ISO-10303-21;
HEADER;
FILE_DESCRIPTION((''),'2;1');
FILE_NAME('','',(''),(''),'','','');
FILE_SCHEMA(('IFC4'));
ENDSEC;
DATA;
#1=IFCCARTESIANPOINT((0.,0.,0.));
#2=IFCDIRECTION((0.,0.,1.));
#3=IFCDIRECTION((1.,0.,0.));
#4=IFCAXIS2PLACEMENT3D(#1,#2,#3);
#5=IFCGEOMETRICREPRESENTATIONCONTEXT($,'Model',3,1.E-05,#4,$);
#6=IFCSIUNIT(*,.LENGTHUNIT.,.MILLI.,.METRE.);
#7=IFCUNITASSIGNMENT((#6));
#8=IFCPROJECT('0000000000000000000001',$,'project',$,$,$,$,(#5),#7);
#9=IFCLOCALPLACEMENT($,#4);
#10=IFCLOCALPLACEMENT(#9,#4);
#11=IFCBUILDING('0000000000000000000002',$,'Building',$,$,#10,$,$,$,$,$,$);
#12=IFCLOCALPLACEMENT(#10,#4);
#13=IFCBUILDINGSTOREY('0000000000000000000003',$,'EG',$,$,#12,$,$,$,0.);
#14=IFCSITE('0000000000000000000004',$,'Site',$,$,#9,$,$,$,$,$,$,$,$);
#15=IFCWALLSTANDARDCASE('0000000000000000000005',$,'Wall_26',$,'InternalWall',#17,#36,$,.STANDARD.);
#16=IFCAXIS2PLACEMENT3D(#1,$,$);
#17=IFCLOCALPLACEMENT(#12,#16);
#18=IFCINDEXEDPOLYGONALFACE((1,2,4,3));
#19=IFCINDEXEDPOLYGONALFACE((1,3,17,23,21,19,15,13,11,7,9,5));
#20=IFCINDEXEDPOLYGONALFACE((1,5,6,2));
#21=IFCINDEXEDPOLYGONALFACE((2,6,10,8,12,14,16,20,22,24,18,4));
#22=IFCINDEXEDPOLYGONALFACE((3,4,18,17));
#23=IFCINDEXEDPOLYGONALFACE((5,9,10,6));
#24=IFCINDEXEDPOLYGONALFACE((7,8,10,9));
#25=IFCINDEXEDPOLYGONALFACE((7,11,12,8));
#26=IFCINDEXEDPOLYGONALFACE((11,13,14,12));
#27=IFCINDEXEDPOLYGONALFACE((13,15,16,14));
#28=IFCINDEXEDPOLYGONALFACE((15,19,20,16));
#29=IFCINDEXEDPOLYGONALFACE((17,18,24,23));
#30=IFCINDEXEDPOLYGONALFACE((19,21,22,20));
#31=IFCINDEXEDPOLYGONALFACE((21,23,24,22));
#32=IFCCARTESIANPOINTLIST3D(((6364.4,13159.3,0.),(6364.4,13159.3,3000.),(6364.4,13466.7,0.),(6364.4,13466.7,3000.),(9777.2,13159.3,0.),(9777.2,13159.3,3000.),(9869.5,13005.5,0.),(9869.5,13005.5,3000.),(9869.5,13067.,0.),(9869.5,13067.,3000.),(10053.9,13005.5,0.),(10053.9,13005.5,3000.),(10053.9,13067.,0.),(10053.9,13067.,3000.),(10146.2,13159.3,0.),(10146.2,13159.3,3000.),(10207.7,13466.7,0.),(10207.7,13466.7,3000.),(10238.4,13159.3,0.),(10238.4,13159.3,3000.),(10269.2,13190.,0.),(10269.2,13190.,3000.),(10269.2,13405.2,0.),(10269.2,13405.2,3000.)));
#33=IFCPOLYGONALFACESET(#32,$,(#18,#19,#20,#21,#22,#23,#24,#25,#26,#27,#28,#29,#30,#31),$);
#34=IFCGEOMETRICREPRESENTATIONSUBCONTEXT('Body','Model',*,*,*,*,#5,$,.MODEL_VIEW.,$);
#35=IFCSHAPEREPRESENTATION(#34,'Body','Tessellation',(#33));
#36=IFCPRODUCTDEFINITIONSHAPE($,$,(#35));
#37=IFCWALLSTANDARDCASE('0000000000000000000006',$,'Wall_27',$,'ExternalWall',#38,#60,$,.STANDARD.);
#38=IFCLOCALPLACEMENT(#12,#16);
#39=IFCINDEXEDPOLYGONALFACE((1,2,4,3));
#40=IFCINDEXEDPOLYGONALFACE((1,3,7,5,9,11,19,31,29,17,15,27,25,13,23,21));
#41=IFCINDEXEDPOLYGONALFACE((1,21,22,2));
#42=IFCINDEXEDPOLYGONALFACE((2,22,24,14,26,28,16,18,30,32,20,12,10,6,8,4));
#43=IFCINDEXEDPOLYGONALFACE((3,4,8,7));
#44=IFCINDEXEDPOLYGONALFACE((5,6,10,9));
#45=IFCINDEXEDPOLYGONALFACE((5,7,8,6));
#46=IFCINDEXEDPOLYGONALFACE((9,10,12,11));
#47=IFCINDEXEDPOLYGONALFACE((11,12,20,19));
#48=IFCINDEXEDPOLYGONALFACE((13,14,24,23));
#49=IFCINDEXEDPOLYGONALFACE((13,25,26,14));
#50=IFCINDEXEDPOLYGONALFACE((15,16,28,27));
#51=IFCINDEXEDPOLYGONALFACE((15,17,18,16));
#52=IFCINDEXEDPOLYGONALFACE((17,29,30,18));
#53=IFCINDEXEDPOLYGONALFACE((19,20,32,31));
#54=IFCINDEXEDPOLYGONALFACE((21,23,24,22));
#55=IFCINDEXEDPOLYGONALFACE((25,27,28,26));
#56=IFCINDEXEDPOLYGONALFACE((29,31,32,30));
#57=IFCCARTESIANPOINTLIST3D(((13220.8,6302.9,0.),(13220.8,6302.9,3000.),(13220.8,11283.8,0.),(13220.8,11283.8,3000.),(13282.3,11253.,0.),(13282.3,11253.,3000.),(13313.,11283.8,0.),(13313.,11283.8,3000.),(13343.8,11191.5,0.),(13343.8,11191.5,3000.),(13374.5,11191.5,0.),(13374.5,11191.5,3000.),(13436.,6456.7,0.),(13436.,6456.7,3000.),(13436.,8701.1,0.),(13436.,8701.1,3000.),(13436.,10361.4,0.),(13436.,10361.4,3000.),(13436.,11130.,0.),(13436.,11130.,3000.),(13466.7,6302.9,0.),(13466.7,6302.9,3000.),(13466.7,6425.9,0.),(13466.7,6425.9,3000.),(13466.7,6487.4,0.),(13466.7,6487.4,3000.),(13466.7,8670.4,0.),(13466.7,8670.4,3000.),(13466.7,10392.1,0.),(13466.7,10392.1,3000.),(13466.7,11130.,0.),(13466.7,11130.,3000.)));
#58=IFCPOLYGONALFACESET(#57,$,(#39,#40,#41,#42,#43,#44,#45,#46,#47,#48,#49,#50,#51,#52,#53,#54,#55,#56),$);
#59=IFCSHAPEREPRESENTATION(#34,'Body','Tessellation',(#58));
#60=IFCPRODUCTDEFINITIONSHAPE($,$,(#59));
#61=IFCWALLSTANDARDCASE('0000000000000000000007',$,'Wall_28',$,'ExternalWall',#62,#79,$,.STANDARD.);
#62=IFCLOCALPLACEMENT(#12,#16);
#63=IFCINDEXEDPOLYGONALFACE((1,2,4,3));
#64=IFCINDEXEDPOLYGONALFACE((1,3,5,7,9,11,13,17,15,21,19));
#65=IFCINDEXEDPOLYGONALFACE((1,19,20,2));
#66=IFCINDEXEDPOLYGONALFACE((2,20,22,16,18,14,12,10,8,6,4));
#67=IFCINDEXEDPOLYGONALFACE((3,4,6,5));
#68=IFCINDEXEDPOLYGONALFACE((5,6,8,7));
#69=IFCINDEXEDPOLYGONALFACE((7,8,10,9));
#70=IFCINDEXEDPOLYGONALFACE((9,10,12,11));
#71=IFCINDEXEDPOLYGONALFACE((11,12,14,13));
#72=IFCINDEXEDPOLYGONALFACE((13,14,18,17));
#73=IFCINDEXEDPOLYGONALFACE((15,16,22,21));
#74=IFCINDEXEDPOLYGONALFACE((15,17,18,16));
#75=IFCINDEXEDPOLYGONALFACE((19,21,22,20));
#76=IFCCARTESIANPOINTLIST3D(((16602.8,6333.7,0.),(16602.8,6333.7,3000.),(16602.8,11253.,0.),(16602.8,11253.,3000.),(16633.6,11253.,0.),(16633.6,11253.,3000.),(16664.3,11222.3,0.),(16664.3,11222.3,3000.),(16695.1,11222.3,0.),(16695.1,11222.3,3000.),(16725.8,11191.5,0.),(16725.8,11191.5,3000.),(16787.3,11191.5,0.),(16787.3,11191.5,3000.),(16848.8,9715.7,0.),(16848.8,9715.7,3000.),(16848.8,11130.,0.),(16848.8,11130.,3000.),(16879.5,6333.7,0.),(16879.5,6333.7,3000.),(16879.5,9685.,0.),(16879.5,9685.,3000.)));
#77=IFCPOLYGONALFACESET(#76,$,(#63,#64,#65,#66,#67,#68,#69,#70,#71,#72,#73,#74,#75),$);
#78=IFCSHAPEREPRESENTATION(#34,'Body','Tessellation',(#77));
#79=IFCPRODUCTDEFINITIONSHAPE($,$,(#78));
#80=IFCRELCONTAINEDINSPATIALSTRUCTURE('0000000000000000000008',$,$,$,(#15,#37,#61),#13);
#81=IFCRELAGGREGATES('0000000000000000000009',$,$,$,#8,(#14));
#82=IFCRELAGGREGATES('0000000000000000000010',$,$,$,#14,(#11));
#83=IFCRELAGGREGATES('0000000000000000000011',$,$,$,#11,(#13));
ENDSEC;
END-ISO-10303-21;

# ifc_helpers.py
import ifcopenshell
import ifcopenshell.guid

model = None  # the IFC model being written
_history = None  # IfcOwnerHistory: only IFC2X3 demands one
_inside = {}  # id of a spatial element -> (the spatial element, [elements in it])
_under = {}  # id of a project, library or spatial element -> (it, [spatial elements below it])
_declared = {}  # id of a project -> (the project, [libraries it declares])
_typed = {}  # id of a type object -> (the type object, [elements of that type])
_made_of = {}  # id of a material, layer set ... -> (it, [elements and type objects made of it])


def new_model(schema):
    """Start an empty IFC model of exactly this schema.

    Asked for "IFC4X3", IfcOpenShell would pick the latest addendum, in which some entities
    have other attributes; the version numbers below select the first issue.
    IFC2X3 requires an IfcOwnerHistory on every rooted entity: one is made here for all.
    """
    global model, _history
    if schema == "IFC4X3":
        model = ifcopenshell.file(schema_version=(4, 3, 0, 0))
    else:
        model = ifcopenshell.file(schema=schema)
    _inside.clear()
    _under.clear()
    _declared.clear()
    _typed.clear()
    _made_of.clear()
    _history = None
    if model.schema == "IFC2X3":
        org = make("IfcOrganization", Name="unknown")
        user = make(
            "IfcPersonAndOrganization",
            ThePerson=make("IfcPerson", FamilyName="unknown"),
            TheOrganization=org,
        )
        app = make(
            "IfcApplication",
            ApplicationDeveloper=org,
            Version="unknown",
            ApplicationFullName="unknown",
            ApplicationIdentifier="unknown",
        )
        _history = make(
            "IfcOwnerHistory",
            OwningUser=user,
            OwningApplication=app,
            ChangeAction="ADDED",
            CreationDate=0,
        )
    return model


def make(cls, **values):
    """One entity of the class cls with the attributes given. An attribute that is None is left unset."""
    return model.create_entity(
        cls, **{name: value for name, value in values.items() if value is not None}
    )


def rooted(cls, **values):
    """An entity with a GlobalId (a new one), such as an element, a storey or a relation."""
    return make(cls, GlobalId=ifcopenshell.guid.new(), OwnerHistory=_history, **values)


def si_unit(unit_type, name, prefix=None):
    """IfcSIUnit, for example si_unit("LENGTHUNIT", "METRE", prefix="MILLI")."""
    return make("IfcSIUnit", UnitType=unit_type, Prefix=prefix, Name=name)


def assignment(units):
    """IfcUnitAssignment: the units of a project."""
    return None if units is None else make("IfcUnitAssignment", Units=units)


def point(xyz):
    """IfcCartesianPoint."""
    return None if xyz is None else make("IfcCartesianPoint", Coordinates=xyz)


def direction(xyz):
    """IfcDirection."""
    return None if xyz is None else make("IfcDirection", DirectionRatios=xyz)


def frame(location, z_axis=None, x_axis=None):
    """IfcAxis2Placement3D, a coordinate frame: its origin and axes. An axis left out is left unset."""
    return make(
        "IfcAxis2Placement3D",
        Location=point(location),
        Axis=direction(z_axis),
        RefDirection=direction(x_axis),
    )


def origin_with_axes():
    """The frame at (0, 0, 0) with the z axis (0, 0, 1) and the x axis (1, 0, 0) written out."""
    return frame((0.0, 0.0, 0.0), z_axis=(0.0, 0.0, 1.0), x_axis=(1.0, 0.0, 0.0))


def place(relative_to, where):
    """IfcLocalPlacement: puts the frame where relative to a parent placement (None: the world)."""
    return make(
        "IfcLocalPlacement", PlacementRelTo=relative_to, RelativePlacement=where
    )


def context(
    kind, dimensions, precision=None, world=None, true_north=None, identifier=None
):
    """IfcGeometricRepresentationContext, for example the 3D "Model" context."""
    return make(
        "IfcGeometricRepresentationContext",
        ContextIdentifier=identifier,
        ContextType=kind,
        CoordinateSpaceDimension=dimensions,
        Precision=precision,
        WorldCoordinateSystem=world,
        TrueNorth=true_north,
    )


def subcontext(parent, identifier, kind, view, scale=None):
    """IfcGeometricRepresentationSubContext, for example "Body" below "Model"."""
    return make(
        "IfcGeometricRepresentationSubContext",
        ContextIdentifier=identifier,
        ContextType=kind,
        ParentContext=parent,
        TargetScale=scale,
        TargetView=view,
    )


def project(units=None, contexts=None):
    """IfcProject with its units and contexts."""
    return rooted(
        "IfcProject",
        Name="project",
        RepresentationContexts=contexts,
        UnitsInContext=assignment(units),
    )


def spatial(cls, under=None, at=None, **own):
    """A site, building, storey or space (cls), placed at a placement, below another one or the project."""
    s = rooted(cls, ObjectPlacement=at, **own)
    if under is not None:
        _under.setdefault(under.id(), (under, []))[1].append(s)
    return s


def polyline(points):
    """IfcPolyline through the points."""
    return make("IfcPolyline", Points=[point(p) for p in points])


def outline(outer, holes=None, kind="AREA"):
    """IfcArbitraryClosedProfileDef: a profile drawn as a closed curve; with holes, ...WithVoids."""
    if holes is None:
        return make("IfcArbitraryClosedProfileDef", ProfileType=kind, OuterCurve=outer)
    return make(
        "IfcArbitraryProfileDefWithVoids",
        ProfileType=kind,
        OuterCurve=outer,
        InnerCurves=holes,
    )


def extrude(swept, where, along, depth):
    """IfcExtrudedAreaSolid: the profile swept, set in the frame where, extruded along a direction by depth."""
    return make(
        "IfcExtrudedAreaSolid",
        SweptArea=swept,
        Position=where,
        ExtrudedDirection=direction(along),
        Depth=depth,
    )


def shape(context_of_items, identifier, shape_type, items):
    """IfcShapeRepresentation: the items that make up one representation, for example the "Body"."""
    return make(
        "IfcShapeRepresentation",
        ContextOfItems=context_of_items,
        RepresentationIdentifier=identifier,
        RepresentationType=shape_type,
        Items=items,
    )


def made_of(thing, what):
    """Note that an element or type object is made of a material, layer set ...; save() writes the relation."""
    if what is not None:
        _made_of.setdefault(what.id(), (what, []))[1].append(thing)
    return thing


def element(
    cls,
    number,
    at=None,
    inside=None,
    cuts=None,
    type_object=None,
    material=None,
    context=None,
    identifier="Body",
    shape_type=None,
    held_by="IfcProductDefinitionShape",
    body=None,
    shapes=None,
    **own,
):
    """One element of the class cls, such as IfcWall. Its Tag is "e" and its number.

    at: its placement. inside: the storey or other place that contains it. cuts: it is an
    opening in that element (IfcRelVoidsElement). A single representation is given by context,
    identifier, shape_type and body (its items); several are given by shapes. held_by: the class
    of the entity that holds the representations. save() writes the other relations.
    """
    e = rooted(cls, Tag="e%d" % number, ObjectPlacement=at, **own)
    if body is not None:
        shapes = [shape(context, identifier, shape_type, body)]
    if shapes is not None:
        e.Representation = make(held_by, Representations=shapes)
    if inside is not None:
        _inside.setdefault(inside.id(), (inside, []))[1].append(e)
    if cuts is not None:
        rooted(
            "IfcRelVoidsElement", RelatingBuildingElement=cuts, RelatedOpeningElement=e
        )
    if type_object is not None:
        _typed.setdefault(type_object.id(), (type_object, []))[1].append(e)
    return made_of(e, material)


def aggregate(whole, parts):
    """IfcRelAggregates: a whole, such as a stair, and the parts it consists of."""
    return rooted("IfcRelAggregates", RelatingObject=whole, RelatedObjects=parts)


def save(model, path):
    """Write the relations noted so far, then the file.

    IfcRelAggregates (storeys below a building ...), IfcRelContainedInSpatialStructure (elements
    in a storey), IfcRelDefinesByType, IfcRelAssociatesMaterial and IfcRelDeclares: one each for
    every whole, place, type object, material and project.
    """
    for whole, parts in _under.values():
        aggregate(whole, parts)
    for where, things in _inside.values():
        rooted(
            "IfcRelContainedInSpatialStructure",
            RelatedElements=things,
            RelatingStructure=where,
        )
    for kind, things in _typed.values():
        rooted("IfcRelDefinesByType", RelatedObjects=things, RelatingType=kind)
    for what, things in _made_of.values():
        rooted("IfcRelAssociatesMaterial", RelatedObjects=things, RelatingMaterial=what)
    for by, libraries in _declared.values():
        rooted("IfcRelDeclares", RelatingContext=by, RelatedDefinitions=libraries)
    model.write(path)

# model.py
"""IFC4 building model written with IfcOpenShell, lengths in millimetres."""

from ifc_helpers import new_model, si_unit, origin_with_axes, place, context, subcontext, project, spatial, polyline, outline, extrude, element, save


model = new_model("IFC4")

# Units and contexts
model_context = context("Model", 3, precision=1e-05, world=origin_with_axes())
body_context = subcontext(model_context, "Body", "Model", "MODEL_VIEW")
ifc_project = project(units=[si_unit("LENGTHUNIT", "METRE", prefix="MILLI")], contexts=[model_context])

# Site, building, storey
site_placement = place(None, origin_with_axes())
site = spatial("IfcSite", under=ifc_project, at=site_placement, Name="Site")
building_placement = place(site_placement, origin_with_axes())
building = spatial("IfcBuilding", under=site, at=building_placement, Name="Building")
storey_placement = place(building_placement, origin_with_axes())
storey = spatial("IfcBuildingStorey", under=building, at=storey_placement, Name="EG", Elevation=0.0)

# Walls
wall_1_placement = place(storey_placement, origin_with_axes())
element("IfcWallStandardCase", 1, at=wall_1_placement, inside=storey, Name="Wall_26", ObjectType="InternalWall", PredefinedType="STANDARD", context=body_context, shape_type="SweptSolid", body=[
    extrude(outline(polyline([(9869.5, 13005.5, 0.0), (9869.5, 13067.0, 0.0), (9777.2, 13159.3, 0.0), (6364.4, 13159.3, 0.0), (6364.4, 13466.7, 0.0), (10207.7, 13466.7, 0.0), (10269.2, 13405.2, 0.0), (10269.2, 13190.0, 0.0), (10238.4, 13159.3, 0.0), (10146.2, 13159.3, 0.0), (10053.9, 13067.0, 0.0), (10053.9, 13005.5, 0.0), (9869.5, 13005.5, 0.0)])), origin_with_axes(), (0.0, 0.0, 1.0), 3000.0),
])
wall_2_placement = place(storey_placement, origin_with_axes())
element("IfcWallStandardCase", 2, at=wall_2_placement, inside=storey, Name="Wall_27", ObjectType="ExternalWall", PredefinedType="STANDARD", context=body_context, shape_type="SweptSolid", body=[
    extrude(outline(polyline([(13220.8, 6302.9, 0.0), (13220.8, 11283.8, 0.0), (13313.0, 11283.8, 0.0), (13282.3, 11253.0, 0.0), (13343.8, 11191.5, 0.0), (13374.5, 11191.5, 0.0), (13436.0, 11130.0, 0.0), (13466.7, 11130.0, 0.0), (13466.7, 10392.1, 0.0), (13436.0, 10361.4, 0.0), (13436.0, 8701.1, 0.0), (13466.7, 8670.4, 0.0), (13466.7, 6487.4, 0.0), (13436.0, 6456.7, 0.0), (13466.7, 6425.9, 0.0), (13466.7, 6302.9, 0.0), (13220.8, 6302.9, 0.0)])), origin_with_axes(), (0.0, 0.0, 1.0), 3000.0),
])
wall_3_placement = place(storey_placement, origin_with_axes())
element("IfcWallStandardCase", 3, at=wall_3_placement, inside=storey, Name="Wall_28", ObjectType="ExternalWall", PredefinedType="STANDARD", context=body_context, shape_type="SweptSolid", body=[
    extrude(outline(polyline([(16602.8, 6333.7, 0.0), (16602.8, 11253.0, 0.0), (16633.6, 11253.0, 0.0), (16664.3, 11222.3, 0.0), (16695.1, 11222.3, 0.0), (16725.8, 11191.5, 0.0), (16787.3, 11191.5, 0.0), (16848.8, 11130.0, 0.0), (16848.8, 9715.7, 0.0), (16879.5, 9685.0, 0.0), (16879.5, 6333.7, 0.0), (16602.8, 6333.7, 0.0)])), origin_with_axes(), (0.0, 0.0, 1.0), 3000.0),
])

save(model, "model.ifc")
